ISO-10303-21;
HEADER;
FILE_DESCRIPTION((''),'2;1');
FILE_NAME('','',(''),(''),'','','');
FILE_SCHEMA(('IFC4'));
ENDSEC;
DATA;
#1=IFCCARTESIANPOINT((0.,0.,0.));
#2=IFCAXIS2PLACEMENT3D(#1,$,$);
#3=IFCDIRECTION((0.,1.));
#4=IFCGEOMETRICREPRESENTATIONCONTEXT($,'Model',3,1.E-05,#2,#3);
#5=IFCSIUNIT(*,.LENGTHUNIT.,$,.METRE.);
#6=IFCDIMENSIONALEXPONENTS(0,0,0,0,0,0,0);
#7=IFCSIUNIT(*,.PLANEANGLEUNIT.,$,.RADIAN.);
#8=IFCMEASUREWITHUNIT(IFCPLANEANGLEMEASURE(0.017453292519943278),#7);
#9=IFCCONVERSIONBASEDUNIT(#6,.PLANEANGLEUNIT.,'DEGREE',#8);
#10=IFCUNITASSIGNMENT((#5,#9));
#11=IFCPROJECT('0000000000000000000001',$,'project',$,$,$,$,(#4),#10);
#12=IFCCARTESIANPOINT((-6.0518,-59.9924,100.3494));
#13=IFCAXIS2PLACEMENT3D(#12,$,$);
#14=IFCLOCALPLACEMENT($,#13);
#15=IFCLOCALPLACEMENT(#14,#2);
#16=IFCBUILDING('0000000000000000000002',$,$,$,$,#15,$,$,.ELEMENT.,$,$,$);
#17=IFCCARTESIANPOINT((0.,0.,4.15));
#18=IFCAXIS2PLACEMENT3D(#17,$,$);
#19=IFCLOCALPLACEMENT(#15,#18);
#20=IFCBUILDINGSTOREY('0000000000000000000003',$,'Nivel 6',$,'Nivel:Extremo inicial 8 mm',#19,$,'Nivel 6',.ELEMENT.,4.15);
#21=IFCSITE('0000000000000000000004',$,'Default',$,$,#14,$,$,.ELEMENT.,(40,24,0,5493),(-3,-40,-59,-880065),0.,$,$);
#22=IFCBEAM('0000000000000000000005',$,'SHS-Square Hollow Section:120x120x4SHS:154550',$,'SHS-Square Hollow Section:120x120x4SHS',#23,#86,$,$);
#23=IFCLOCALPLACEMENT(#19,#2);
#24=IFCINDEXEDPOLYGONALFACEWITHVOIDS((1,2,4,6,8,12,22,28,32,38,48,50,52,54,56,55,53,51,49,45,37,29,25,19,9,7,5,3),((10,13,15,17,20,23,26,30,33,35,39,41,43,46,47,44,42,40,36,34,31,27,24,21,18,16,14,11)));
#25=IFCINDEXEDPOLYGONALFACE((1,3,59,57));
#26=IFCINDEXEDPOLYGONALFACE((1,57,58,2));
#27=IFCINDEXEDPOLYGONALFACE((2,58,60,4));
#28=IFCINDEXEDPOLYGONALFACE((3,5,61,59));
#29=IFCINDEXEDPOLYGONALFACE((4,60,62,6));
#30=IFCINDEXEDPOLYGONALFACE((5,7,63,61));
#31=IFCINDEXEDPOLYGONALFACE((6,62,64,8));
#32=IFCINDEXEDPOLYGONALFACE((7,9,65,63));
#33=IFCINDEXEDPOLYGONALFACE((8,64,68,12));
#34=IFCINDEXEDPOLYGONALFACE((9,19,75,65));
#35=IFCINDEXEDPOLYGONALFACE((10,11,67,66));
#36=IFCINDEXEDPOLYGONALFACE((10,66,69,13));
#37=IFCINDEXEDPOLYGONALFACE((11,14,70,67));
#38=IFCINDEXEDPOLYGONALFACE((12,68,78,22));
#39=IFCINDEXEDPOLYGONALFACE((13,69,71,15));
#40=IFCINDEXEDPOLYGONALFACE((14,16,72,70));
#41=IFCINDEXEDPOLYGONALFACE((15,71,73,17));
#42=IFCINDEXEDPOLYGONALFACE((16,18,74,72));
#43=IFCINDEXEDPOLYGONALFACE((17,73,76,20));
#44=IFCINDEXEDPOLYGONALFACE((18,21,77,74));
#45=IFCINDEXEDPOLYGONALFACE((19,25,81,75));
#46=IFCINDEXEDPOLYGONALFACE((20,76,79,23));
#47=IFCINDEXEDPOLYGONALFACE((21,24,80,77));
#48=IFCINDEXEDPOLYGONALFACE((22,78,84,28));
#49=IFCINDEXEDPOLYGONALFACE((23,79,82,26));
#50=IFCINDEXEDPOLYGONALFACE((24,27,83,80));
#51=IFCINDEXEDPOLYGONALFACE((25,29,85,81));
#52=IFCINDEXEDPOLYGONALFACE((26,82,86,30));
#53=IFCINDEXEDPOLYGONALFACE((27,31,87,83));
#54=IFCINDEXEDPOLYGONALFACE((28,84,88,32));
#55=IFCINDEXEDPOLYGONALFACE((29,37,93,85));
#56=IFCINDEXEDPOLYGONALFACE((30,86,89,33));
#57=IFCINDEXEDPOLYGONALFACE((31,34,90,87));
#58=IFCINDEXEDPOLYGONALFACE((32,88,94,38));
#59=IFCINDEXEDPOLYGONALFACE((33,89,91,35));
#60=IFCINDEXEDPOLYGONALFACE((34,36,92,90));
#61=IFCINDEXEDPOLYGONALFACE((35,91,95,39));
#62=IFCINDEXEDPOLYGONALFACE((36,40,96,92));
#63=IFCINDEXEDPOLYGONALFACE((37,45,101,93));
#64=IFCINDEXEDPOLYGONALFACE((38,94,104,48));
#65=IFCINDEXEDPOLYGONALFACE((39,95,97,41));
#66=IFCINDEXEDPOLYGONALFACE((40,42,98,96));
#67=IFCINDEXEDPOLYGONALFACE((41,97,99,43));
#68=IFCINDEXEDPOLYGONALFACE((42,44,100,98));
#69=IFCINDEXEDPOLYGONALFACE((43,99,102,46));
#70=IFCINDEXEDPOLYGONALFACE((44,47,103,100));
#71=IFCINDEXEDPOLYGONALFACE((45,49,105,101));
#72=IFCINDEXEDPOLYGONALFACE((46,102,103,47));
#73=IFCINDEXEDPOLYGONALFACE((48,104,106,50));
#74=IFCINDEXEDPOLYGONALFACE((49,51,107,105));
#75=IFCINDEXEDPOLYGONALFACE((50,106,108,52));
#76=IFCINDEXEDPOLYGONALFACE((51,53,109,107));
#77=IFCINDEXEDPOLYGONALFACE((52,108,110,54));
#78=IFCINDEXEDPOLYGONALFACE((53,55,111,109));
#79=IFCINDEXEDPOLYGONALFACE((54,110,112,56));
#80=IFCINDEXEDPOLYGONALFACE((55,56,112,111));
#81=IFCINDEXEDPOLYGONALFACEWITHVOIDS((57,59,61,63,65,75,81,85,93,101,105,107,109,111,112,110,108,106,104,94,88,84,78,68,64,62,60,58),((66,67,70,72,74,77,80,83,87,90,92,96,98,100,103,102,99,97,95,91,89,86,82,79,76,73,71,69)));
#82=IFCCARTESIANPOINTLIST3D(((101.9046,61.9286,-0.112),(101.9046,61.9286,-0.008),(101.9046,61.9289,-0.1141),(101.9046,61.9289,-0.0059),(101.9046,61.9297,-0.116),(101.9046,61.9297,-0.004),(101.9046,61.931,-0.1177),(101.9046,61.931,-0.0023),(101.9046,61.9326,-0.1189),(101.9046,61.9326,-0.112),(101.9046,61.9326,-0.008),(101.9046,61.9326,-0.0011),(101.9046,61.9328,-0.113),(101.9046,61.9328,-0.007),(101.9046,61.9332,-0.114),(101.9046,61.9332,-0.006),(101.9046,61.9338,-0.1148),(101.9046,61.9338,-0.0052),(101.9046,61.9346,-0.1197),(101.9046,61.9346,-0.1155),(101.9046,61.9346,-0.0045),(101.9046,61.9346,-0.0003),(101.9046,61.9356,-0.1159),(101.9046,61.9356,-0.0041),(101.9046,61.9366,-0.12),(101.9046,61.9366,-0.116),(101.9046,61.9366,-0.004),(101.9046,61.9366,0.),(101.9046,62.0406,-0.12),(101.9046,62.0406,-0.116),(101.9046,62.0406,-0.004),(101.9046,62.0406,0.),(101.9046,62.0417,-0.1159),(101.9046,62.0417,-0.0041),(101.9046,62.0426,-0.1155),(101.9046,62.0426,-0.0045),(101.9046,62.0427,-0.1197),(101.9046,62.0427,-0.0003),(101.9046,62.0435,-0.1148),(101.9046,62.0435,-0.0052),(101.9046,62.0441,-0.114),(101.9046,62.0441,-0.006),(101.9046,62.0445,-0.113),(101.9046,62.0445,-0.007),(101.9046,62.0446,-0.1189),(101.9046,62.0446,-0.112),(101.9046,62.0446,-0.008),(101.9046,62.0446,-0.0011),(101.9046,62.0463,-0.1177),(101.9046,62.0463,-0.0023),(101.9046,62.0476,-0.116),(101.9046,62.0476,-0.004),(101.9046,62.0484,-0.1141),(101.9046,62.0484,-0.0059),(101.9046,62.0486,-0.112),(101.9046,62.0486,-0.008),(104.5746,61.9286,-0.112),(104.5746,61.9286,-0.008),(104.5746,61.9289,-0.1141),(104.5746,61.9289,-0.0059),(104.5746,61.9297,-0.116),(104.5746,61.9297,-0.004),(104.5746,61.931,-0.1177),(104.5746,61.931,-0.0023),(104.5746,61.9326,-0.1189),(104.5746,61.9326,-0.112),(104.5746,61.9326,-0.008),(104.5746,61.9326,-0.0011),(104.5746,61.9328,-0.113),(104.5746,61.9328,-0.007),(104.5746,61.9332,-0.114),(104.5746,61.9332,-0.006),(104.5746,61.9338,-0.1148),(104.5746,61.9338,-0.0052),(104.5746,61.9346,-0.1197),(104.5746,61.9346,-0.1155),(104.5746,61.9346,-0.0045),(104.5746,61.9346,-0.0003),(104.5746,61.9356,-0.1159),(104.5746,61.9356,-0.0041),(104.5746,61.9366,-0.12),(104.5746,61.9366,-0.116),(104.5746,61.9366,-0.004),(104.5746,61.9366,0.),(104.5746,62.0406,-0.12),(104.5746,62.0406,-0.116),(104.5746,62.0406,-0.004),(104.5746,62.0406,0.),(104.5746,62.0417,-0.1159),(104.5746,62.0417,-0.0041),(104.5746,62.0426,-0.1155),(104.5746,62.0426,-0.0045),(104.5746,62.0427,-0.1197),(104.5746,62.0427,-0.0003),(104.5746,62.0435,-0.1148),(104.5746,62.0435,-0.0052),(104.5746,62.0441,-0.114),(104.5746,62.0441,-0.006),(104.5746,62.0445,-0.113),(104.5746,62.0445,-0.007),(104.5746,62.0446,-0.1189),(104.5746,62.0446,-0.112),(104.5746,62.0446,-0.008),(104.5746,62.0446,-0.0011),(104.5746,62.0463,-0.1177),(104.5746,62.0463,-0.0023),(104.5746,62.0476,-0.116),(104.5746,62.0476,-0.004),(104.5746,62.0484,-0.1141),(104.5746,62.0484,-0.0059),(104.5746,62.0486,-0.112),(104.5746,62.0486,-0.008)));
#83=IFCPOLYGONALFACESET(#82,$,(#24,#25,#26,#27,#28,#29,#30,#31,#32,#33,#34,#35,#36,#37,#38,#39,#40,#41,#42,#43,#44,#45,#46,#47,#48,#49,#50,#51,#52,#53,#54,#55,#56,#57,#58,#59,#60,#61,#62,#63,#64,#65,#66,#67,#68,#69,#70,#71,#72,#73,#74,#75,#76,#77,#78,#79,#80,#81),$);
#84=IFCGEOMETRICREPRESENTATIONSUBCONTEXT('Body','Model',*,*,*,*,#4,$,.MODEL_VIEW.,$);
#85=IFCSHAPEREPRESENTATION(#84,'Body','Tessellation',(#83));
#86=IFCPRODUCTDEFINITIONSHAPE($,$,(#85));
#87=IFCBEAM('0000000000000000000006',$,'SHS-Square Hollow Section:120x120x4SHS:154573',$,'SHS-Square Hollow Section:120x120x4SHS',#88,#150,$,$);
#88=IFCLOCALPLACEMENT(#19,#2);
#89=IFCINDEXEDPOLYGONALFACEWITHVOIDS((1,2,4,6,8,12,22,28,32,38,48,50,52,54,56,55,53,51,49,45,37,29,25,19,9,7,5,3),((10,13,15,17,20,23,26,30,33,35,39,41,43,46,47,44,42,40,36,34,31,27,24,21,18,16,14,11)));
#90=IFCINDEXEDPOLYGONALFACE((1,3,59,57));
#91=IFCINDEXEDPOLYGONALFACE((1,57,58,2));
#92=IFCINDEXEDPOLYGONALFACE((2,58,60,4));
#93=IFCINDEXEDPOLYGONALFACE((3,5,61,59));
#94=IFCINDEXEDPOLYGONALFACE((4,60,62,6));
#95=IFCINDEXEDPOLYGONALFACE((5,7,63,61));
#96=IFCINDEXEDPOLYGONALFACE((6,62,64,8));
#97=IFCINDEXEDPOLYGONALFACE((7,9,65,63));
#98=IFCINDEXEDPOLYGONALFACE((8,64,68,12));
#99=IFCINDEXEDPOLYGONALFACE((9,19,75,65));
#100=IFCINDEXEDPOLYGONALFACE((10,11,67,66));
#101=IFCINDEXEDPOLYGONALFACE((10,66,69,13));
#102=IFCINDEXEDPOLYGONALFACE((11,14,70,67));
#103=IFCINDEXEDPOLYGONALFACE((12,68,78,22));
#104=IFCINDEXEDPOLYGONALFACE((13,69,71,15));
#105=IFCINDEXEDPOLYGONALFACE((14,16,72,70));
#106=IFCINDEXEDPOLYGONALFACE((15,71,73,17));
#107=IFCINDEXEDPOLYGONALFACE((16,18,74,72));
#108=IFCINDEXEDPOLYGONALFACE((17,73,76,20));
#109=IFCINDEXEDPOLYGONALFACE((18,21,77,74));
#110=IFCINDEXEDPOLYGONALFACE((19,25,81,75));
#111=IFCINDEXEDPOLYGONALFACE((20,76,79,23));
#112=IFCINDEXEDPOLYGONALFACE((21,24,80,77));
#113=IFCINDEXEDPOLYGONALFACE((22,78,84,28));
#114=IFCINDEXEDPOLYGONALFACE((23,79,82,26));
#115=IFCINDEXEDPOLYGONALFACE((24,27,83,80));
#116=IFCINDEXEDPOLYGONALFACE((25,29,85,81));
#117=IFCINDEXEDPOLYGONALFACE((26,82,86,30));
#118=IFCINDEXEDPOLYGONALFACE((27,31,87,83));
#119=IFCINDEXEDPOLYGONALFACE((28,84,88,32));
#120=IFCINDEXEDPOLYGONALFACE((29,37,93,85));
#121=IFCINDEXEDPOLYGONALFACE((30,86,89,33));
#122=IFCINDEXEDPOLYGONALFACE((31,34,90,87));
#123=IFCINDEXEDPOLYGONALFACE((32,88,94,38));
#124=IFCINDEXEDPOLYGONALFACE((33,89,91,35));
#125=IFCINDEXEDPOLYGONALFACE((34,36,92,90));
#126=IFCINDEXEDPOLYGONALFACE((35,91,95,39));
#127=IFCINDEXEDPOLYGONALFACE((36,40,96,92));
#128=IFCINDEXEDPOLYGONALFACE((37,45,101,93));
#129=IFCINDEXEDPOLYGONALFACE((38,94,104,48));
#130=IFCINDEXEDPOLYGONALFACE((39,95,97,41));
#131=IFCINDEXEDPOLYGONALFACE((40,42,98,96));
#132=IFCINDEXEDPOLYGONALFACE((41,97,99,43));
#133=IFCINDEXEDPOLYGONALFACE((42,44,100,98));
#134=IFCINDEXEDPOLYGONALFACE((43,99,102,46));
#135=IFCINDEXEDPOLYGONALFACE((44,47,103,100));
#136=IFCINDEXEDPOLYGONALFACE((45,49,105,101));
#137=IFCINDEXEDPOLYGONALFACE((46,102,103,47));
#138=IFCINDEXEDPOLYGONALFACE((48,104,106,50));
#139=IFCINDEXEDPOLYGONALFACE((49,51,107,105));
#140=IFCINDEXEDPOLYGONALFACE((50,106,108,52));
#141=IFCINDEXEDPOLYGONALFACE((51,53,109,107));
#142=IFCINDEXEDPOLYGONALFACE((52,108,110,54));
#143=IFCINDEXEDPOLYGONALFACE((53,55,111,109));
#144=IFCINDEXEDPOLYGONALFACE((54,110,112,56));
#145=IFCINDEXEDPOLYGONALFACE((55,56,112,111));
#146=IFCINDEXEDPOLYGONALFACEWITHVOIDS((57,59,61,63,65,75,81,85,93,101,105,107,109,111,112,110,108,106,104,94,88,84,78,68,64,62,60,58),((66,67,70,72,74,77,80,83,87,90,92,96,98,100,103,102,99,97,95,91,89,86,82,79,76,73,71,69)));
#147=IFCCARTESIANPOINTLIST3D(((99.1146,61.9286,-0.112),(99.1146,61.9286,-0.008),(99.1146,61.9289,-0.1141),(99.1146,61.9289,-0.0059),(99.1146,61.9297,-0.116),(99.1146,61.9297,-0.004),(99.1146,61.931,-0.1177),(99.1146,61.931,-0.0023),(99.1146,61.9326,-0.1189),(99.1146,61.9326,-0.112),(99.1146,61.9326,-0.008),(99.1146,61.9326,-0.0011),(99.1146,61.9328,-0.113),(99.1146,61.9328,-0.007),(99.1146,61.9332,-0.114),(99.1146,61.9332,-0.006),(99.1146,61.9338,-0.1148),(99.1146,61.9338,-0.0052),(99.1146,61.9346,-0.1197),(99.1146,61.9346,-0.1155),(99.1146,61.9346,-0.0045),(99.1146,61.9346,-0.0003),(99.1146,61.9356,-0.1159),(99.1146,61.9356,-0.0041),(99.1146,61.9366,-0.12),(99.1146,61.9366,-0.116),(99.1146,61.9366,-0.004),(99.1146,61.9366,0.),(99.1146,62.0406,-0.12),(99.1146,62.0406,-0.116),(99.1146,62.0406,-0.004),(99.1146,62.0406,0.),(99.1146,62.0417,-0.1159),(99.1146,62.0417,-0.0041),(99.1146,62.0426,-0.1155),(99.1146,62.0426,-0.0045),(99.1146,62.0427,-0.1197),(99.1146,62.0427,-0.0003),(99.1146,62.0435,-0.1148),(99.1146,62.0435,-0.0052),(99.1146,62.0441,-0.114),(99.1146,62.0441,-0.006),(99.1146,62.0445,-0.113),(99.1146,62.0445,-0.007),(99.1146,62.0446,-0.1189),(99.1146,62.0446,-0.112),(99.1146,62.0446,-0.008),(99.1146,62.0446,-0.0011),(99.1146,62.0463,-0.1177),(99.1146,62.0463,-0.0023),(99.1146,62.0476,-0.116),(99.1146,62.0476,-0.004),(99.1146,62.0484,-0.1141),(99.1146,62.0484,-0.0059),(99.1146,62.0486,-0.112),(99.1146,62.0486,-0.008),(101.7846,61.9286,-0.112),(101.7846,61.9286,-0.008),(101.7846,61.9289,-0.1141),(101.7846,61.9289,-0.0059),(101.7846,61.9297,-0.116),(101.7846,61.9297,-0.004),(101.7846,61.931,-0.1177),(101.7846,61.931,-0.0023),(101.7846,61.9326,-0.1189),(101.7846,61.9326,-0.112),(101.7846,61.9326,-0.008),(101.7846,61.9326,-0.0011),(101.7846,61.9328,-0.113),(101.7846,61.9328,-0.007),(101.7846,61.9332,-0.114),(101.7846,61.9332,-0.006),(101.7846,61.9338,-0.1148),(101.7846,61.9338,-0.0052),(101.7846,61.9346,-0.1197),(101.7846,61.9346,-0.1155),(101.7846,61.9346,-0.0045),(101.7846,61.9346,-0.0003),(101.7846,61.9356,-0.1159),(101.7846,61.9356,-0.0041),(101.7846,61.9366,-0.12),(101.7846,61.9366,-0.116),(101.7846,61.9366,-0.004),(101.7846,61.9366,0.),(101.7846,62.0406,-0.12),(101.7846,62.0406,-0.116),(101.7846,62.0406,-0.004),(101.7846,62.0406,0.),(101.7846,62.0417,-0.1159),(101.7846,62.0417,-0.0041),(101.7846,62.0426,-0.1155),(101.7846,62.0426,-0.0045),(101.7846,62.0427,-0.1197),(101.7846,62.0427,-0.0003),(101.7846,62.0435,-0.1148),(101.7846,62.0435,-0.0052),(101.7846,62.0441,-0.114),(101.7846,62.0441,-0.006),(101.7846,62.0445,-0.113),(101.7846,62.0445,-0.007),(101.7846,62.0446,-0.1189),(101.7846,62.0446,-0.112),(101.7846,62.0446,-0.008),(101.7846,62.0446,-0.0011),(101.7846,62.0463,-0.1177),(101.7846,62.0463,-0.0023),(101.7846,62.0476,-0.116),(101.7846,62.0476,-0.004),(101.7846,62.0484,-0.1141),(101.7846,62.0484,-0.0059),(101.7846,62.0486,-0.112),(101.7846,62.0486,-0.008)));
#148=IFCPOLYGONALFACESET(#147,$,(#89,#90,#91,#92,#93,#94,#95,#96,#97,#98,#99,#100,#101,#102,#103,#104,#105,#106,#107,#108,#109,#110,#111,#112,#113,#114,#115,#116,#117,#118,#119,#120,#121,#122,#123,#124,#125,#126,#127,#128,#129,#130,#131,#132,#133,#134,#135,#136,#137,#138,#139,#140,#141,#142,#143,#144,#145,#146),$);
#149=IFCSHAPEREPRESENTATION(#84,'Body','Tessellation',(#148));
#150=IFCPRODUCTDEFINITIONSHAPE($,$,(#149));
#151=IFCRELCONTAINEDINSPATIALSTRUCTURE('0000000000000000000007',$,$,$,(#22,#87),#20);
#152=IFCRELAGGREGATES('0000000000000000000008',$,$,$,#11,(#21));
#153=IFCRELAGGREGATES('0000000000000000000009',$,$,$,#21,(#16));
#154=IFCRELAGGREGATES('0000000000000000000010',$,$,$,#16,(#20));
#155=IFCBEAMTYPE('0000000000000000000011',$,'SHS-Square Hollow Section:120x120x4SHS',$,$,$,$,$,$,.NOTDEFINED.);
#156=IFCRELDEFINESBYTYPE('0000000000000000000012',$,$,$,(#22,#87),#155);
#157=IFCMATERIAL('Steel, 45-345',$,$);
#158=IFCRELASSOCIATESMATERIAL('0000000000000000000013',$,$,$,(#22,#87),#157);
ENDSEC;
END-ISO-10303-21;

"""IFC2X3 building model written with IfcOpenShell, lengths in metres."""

from ifc_helpers import new_model, entity, si_unit, converted_unit, direction, frame, frame_2d, origin, place, context, subcontext, project, spatial, polyline, circle_curve, parameter, trimmed, segment, composite_curve, outline, extrude, material, type_object, element, save


model = new_model("IFC2X3")

# Units and contexts
model_context = context("Model", 3, precision=1e-05, world=origin(), true_north=direction((0.0, 1.0)))
body_context = subcontext(model_context, "Body", "Model", "MODEL_VIEW")
ifc_project = project(units=[si_unit("LENGTHUNIT", "METRE"), converted_unit("PLANEANGLEUNIT", "DEGREE", entity("IfcPlaneAngleMeasure", 0.017453292519943278), si_unit("PLANEANGLEUNIT", "RADIAN"), dimensions=[0, 0, 0, 0, 0, 0, 0])], contexts=[model_context])

# Site, building, storey
site_placement = place(None, frame((-6.0518, -59.9924, 100.3494)))
site = spatial("IfcSite", under=ifc_project, at=site_placement, Name="Default", CompositionType="ELEMENT", RefLatitude=(40, 24, 0, 5493), RefLongitude=(-3, -40, -59, -880065), RefElevation=0.0)
building_placement = place(site_placement, origin())
building = spatial("IfcBuilding", under=site, at=building_placement, CompositionType="ELEMENT")
storey_placement = place(building_placement, frame((0.0, 0.0, 4.15)))
storey = spatial("IfcBuildingStorey", under=building, at=storey_placement, Name="Nivel 6", ObjectType="Nivel:Extremo inicial 8 mm", LongName="Nivel 6", CompositionType="ELEMENT", Elevation=4.15)

# Beams
ifc_material_1 = material(Name="Steel, 45-345")
beam_type_1 = type_object("IfcBeamType", Name="SHS-Square Hollow Section:120x120x4SHS", PredefinedType="NOTDEFINED")
beam_1_placement = place(storey_placement, frame((104.6346, 61.9886, 0.0), z_axis=(0.0, 0.0, 1.0), x_axis=(-1.0, 0.0, 0.0)))
element("IfcBeam", 1, at=beam_1_placement, inside=storey, type_object=beam_type_1, material=ifc_material_1, Name="SHS-Square Hollow Section:120x120x4SHS:154550", ObjectType="SHS-Square Hollow Section:120x120x4SHS", context=body_context, shape_type="SweptSolid", body=[
    extrude(outline(composite_curve([segment(trimmed(circle_curve(frame_2d((-0.052, -0.052), x_axis=(1.0, 0.0)), 0.008), [parameter(180.0)], [parameter(270.0)], True, "PARAMETER"), True, "CONTINUOUS"), segment(polyline([(-0.052, -0.06), (0.052, -0.06)]), True, "CONTINUOUS"), segment(trimmed(circle_curve(frame_2d((0.052, -0.052), x_axis=(1.0, 0.0)), 0.008), [parameter(270.0)], [parameter(0.0)], True, "PARAMETER"), True, "CONTINUOUS"), segment(polyline([(0.06, -0.052), (0.06, 0.052)]), True, "CONTINUOUS"), segment(trimmed(circle_curve(frame_2d((0.052, 0.052), x_axis=(1.0, 0.0)), 0.008), [parameter(360.0)], [parameter(90.0)], True, "PARAMETER"), True, "CONTINUOUS"), segment(polyline([(0.052, 0.06), (-0.052, 0.06)]), True, "CONTINUOUS"), segment(trimmed(circle_curve(frame_2d((-0.052, 0.052), x_axis=(1.0, 0.0)), 0.008), [parameter(90.0)], [parameter(180.0)], True, "PARAMETER"), True, "CONTINUOUS"), segment(polyline([(-0.06, 0.052), (-0.06, -0.052)]), True, "CONTINUOUS")], self_intersect=False), holes=[composite_curve([segment(polyline([(0.052, -0.056), (-0.052, -0.056)]), True, "CONTINUOUS"), segment(trimmed(circle_curve(frame_2d((-0.052, -0.052), x_axis=(1.0, 0.0)), 0.004), [parameter(180.0)], [parameter(270.0)], True, "PARAMETER"), False, "CONTINUOUS"), segment(polyline([(-0.056, -0.052), (-0.056, 0.052)]), True, "CONTINUOUS"), segment(trimmed(circle_curve(frame_2d((-0.052, 0.052), x_axis=(1.0, 0.0)), 0.004), [parameter(90.0)], [parameter(180.0)], True, "PARAMETER"), False, "CONTINUOUS"), segment(polyline([(-0.052, 0.056), (0.052, 0.056)]), True, "CONTINUOUS"), segment(trimmed(circle_curve(frame_2d((0.052, 0.052), x_axis=(1.0, 0.0)), 0.004), [parameter(0.0)], [parameter(90.0)], True, "PARAMETER"), False, "CONTINUOUS"), segment(polyline([(0.056, 0.052), (0.056, -0.052)]), True, "CONTINUOUS"), segment(trimmed(circle_curve(frame_2d((0.052, -0.052), x_axis=(1.0, 0.0)), 0.004), [parameter(270.0)], [parameter(0.0)], True, "PARAMETER"), False, "CONTINUOUS")], self_intersect=False)]), frame((0.06, 0.0, -0.06), z_axis=(1.0, 0.0, 0.0), x_axis=(0.0, -1.0, 0.0)), (0.0, 0.0, 1.0), 2.67),
])
beam_2_placement = place(storey_placement, frame((101.8446, 61.9886, 0.0), z_axis=(0.0, 0.0, 1.0), x_axis=(-1.0, 0.0, 0.0)))
element("IfcBeam", 2, at=beam_2_placement, inside=storey, type_object=beam_type_1, material=ifc_material_1, Name="SHS-Square Hollow Section:120x120x4SHS:154573", ObjectType="SHS-Square Hollow Section:120x120x4SHS", context=body_context, shape_type="SweptSolid", body=[
    extrude(outline(composite_curve([segment(trimmed(circle_curve(frame_2d((-0.052, -0.052), x_axis=(1.0, 0.0)), 0.008), [parameter(180.0)], [parameter(270.0)], True, "PARAMETER"), True, "CONTINUOUS"), segment(polyline([(-0.052, -0.06), (0.052, -0.06)]), True, "CONTINUOUS"), segment(trimmed(circle_curve(frame_2d((0.052, -0.052), x_axis=(1.0, 0.0)), 0.008), [parameter(270.0)], [parameter(0.0)], True, "PARAMETER"), True, "CONTINUOUS"), segment(polyline([(0.06, -0.052), (0.06, 0.052)]), True, "CONTINUOUS"), segment(trimmed(circle_curve(frame_2d((0.052, 0.052), x_axis=(1.0, 0.0)), 0.008), [parameter(360.0)], [parameter(90.0)], True, "PARAMETER"), True, "CONTINUOUS"), segment(polyline([(0.052, 0.06), (-0.052, 0.06)]), True, "CONTINUOUS"), segment(trimmed(circle_curve(frame_2d((-0.052, 0.052), x_axis=(1.0, 0.0)), 0.008), [parameter(90.0)], [parameter(180.0)], True, "PARAMETER"), True, "CONTINUOUS"), segment(polyline([(-0.06, 0.052), (-0.06, -0.052)]), True, "CONTINUOUS")], self_intersect=False), holes=[composite_curve([segment(polyline([(0.052, -0.056), (-0.052, -0.056)]), True, "CONTINUOUS"), segment(trimmed(circle_curve(frame_2d((-0.052, -0.052), x_axis=(1.0, 0.0)), 0.004), [parameter(180.0)], [parameter(270.0)], True, "PARAMETER"), False, "CONTINUOUS"), segment(polyline([(-0.056, -0.052), (-0.056, 0.052)]), True, "CONTINUOUS"), segment(trimmed(circle_curve(frame_2d((-0.052, 0.052), x_axis=(1.0, 0.0)), 0.004), [parameter(90.0)], [parameter(180.0)], True, "PARAMETER"), False, "CONTINUOUS"), segment(polyline([(-0.052, 0.056), (0.052, 0.056)]), True, "CONTINUOUS"), segment(trimmed(circle_curve(frame_2d((0.052, 0.052), x_axis=(1.0, 0.0)), 0.004), [parameter(0.0)], [parameter(90.0)], True, "PARAMETER"), False, "CONTINUOUS"), segment(polyline([(0.056, 0.052), (0.056, -0.052)]), True, "CONTINUOUS"), segment(trimmed(circle_curve(frame_2d((0.052, -0.052), x_axis=(1.0, 0.0)), 0.004), [parameter(270.0)], [parameter(0.0)], True, "PARAMETER"), False, "CONTINUOUS")], self_intersect=False)]), frame((0.06, 0.0, -0.06), z_axis=(1.0, 0.0, 0.0), x_axis=(0.0, -1.0, 0.0)), (0.0, 0.0, 1.0), 2.67),
])

save(model, "model.ifc")
